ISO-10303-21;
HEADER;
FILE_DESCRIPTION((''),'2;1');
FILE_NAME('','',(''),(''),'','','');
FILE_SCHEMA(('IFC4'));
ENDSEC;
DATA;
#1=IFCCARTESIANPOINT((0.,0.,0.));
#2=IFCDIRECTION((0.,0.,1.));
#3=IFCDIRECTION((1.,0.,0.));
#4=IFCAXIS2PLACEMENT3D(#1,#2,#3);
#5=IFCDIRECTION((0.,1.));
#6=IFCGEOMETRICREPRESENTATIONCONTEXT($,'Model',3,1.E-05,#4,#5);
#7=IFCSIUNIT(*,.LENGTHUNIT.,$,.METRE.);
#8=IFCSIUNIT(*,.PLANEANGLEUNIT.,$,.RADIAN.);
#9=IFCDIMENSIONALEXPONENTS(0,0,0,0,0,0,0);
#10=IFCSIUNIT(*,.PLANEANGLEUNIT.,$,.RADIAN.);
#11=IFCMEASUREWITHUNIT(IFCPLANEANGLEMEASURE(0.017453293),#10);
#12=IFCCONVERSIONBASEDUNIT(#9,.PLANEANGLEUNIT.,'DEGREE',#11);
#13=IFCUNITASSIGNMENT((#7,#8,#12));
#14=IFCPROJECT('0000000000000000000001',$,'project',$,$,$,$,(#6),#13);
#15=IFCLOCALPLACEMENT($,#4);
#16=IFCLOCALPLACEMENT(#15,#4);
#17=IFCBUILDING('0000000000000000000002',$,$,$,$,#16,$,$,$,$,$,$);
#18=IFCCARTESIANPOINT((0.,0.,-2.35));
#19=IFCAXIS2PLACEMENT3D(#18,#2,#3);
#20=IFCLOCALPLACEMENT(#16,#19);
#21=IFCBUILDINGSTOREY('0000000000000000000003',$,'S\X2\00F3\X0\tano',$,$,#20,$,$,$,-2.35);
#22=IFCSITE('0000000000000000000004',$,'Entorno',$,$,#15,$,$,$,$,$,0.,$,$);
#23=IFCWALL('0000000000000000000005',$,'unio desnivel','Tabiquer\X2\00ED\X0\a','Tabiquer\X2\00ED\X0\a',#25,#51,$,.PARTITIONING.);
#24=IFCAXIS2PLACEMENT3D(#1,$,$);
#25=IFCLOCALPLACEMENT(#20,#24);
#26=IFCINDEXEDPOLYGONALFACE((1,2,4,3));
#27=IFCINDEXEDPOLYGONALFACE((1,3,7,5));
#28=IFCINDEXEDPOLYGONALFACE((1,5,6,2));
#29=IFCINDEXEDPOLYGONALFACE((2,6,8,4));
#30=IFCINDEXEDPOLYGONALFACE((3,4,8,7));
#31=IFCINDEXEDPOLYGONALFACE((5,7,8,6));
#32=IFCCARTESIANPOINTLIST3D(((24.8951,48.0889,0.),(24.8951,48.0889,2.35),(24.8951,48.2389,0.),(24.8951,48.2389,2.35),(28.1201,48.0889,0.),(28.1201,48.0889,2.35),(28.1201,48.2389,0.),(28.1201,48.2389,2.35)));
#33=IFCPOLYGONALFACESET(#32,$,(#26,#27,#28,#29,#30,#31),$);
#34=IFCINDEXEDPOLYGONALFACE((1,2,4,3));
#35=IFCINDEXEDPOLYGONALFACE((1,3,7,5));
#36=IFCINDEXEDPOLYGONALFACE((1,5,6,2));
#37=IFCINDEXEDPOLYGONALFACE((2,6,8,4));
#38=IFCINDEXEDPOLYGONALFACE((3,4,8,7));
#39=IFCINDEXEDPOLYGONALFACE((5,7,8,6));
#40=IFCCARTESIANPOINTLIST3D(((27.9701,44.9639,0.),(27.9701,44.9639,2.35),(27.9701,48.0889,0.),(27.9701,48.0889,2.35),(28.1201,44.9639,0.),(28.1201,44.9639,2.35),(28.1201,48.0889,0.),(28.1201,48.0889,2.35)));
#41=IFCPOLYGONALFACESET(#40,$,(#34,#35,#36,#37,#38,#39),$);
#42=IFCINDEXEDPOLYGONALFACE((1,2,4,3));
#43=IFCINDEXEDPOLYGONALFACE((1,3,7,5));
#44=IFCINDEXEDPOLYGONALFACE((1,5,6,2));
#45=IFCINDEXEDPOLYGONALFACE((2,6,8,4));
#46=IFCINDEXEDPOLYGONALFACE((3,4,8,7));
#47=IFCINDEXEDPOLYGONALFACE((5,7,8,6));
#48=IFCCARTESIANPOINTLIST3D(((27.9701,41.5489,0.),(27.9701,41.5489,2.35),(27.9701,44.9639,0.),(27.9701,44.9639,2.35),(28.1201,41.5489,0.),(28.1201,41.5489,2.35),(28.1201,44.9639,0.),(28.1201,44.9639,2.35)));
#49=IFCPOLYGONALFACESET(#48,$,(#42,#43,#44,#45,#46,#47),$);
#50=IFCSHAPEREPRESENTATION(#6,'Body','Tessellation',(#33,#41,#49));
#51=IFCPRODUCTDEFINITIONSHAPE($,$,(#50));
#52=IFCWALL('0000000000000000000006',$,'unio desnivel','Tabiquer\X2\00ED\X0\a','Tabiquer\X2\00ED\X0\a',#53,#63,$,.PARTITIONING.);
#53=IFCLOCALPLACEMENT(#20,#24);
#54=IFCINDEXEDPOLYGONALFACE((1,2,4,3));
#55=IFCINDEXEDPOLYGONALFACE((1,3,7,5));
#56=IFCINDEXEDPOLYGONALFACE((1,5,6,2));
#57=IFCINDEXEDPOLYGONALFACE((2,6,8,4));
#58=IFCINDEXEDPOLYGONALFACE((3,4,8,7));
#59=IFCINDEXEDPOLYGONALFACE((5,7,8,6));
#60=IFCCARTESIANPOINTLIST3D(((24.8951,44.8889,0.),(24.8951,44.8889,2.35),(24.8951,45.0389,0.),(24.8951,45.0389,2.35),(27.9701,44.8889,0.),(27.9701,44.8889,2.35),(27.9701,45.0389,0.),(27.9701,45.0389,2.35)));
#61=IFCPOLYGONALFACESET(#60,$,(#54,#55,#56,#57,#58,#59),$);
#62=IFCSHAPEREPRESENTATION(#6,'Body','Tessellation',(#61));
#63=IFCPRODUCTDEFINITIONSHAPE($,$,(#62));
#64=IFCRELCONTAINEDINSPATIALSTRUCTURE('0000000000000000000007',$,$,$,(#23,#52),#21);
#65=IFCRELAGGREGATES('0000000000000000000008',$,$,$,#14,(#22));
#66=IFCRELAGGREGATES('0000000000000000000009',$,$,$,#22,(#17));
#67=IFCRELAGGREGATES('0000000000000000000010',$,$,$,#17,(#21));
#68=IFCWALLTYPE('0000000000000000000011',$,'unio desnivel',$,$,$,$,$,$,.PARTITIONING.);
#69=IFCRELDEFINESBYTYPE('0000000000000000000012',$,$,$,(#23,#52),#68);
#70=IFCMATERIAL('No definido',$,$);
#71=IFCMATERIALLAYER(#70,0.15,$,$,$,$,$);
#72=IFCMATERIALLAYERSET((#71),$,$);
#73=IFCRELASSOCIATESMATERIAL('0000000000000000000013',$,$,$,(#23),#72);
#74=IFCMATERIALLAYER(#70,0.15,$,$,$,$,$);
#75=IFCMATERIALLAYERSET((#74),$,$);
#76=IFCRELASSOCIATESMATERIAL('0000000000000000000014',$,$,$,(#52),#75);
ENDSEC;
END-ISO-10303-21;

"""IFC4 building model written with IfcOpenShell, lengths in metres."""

from ifc_helpers import new_model, entity, si_unit, converted_unit, direction, frame, origin_with_axes, place, context, project, spatial, material, layer, layer_set, layer_usage, type_object, element, save


model = new_model("IFC4")

# Units and contexts
model_context = context("Model", 3, precision=1e-05, world=origin_with_axes(), true_north=direction((0.0, 1.0)))
ifc_project = project(units=[si_unit("LENGTHUNIT", "METRE"), si_unit("PLANEANGLEUNIT", "RADIAN"), converted_unit("PLANEANGLEUNIT", "DEGREE", entity("IfcPlaneAngleMeasure", 0.017453293), si_unit("PLANEANGLEUNIT", "RADIAN"), dimensions=[0, 0, 0, 0, 0, 0, 0])], contexts=[model_context])

# Site, building, storey
site_placement = place(None, origin_with_axes())
site = spatial("IfcSite", under=ifc_project, at=site_placement, Name="Entorno", RefElevation=0.0)
building_placement = place(site_placement, origin_with_axes())
building = spatial("IfcBuilding", under=site, at=building_placement)
storey_placement = place(building_placement, frame((0.0, 0.0, -2.35), z_axis=(0.0, 0.0, 1.0), x_axis=(1.0, 0.0, 0.0)))
storey = spatial("IfcBuildingStorey", under=building, at=storey_placement, Name="Sótano", Elevation=-2.35)

# Shared definitions
ifc_material = material(Name="No definido")

# Walls
ifc_layer_1 = layer(ifc_material, 0.15)
ifc_layer_set_1 = layer_set([ifc_layer_1])
ifc_layer_usage_1 = layer_usage(ifc_layer_set_1, "AXIS2", "POSITIVE", -0.075)
wall_type_1 = type_object("IfcWallType", Name="unio desnivel", PredefinedType="PARTITIONING")
wall_1_placement = place(storey_placement, frame((24.8201, 48.1639, 0.0), z_axis=(0.0, 0.0, 1.0), x_axis=(1.0, 0.0, 0.0)))
cartesian_point_1 = entity("IfcCartesianPoint", [-1.6125, -1.175])
cartesian_point_2 = entity("IfcCartesianPoint", [-1.6125, -1.175])
cartesian_point_3 = entity("IfcCartesianPoint", [-1.5625, -1.175])
cartesian_point_4 = entity("IfcCartesianPoint", [-1.5625, -1.175])
cartesian_point_5 = entity("IfcCartesianPoint", [-1.7075, -1.175])
cartesian_point_6 = entity("IfcCartesianPoint", [-1.7075, -1.175])
element("IfcWall", 1, at=wall_1_placement, inside=storey, type_object=wall_type_1, material=ifc_layer_usage_1, Name="unio desnivel", Description="Tabiquería", ObjectType="Tabiquería", PredefinedType="PARTITIONING", context=model_context, shape_type="SolidModel", body=[
    entity("IfcExtrudedAreaSolidTapered", entity("IfcArbitraryClosedProfileDef", "AREA", None, entity("IfcPolyline", [cartesian_point_1, entity("IfcCartesianPoint", [1.6125, -1.175]), entity("IfcCartesianPoint", [1.6125, 1.175]), entity("IfcCartesianPoint", [-1.6125, 1.175]), cartesian_point_1])), entity("IfcAxis2Placement3D", entity("IfcCartesianPoint", [1.6875, 0.075, 1.175]), entity("IfcDirection", [0.0, -1.0, 0.0]), entity("IfcDirection", [1.0, 0.0, 0.0])), entity("IfcDirection", [0.0, 0.0, 1.0]), 0.15, entity("IfcArbitraryClosedProfileDef", "AREA", None, entity("IfcPolyline", [cartesian_point_2, entity("IfcCartesianPoint", [1.6125, -1.175]), entity("IfcCartesianPoint", [1.6125, 1.175]), entity("IfcCartesianPoint", [-1.6125, 1.175]), cartesian_point_2]))),
    entity("IfcExtrudedAreaSolidTapered", entity("IfcArbitraryClosedProfileDef", "AREA", None, entity("IfcPolyline", [cartesian_point_3, entity("IfcCartesianPoint", [1.5625, -1.175]), entity("IfcCartesianPoint", [1.5625, 1.175]), entity("IfcCartesianPoint", [-1.5625, 1.175]), cartesian_point_3])), entity("IfcAxis2Placement3D", entity("IfcCartesianPoint", [3.3, -1.6375, 1.175]), entity("IfcDirection", [-1.0, 0.0, 0.0]), entity("IfcDirection", [0.0, -1.0, 0.0])), entity("IfcDirection", [0.0, 0.0, 1.0]), 0.15, entity("IfcArbitraryClosedProfileDef", "AREA", None, entity("IfcPolyline", [cartesian_point_4, entity("IfcCartesianPoint", [1.5625, -1.175]), entity("IfcCartesianPoint", [1.5625, 1.175]), entity("IfcCartesianPoint", [-1.5625, 1.175]), cartesian_point_4]))),
    entity("IfcExtrudedAreaSolidTapered", entity("IfcArbitraryClosedProfileDef", "AREA", None, entity("IfcPolyline", [cartesian_point_5, entity("IfcCartesianPoint", [1.7075, -1.175]), entity("IfcCartesianPoint", [1.7075, 1.175]), entity("IfcCartesianPoint", [-1.7075, 1.175]), cartesian_point_5])), entity("IfcAxis2Placement3D", entity("IfcCartesianPoint", [3.3, -4.9075, 1.175]), entity("IfcDirection", [-1.0, 0.0, 0.0]), entity("IfcDirection", [0.0, -1.0, 0.0])), entity("IfcDirection", [0.0, 0.0, 1.0]), 0.15, entity("IfcArbitraryClosedProfileDef", "AREA", None, entity("IfcPolyline", [cartesian_point_6, entity("IfcCartesianPoint", [1.7075, -1.175]), entity("IfcCartesianPoint", [1.7075, 1.175]), entity("IfcCartesianPoint", [-1.7075, 1.175]), cartesian_point_6]))),
])
ifc_layer_2 = layer(ifc_material, 0.15)
ifc_layer_set_2 = layer_set([ifc_layer_2])
ifc_layer_usage_2 = layer_usage(ifc_layer_set_2, "AXIS2", "POSITIVE", -0.075)
wall_2_placement = place(storey_placement, frame((28.1201, 44.9639, 0.0), z_axis=(0.0, 0.0, 1.0), x_axis=(-1.0, 0.0, 0.0)))
cartesian_point_7 = entity("IfcCartesianPoint", [-1.5375, -1.175])
cartesian_point_8 = entity("IfcCartesianPoint", [-1.5375, -1.175])
element("IfcWall", 2, at=wall_2_placement, inside=storey, type_object=wall_type_1, material=ifc_layer_usage_2, Name="unio desnivel", Description="Tabiquería", ObjectType="Tabiquería", PredefinedType="PARTITIONING", context=model_context, shape_type="SolidModel", body=[
    entity("IfcExtrudedAreaSolidTapered", entity("IfcArbitraryClosedProfileDef", "AREA", None, entity("IfcPolyline", [cartesian_point_7, entity("IfcCartesianPoint", [1.5375, -1.175]), entity("IfcCartesianPoint", [1.5375, 1.175]), entity("IfcCartesianPoint", [-1.5375, 1.175]), cartesian_point_7])), entity("IfcAxis2Placement3D", entity("IfcCartesianPoint", [1.6875, 0.075, 1.175]), entity("IfcDirection", [0.0, -1.0, 0.0]), entity("IfcDirection", [1.0, 0.0, 0.0])), entity("IfcDirection", [0.0, 0.0, 1.0]), 0.15, entity("IfcArbitraryClosedProfileDef", "AREA", None, entity("IfcPolyline", [cartesian_point_8, entity("IfcCartesianPoint", [1.5375, -1.175]), entity("IfcCartesianPoint", [1.5375, 1.175]), entity("IfcCartesianPoint", [-1.5375, 1.175]), cartesian_point_8]))),
])

save(model, "model.ifc")
